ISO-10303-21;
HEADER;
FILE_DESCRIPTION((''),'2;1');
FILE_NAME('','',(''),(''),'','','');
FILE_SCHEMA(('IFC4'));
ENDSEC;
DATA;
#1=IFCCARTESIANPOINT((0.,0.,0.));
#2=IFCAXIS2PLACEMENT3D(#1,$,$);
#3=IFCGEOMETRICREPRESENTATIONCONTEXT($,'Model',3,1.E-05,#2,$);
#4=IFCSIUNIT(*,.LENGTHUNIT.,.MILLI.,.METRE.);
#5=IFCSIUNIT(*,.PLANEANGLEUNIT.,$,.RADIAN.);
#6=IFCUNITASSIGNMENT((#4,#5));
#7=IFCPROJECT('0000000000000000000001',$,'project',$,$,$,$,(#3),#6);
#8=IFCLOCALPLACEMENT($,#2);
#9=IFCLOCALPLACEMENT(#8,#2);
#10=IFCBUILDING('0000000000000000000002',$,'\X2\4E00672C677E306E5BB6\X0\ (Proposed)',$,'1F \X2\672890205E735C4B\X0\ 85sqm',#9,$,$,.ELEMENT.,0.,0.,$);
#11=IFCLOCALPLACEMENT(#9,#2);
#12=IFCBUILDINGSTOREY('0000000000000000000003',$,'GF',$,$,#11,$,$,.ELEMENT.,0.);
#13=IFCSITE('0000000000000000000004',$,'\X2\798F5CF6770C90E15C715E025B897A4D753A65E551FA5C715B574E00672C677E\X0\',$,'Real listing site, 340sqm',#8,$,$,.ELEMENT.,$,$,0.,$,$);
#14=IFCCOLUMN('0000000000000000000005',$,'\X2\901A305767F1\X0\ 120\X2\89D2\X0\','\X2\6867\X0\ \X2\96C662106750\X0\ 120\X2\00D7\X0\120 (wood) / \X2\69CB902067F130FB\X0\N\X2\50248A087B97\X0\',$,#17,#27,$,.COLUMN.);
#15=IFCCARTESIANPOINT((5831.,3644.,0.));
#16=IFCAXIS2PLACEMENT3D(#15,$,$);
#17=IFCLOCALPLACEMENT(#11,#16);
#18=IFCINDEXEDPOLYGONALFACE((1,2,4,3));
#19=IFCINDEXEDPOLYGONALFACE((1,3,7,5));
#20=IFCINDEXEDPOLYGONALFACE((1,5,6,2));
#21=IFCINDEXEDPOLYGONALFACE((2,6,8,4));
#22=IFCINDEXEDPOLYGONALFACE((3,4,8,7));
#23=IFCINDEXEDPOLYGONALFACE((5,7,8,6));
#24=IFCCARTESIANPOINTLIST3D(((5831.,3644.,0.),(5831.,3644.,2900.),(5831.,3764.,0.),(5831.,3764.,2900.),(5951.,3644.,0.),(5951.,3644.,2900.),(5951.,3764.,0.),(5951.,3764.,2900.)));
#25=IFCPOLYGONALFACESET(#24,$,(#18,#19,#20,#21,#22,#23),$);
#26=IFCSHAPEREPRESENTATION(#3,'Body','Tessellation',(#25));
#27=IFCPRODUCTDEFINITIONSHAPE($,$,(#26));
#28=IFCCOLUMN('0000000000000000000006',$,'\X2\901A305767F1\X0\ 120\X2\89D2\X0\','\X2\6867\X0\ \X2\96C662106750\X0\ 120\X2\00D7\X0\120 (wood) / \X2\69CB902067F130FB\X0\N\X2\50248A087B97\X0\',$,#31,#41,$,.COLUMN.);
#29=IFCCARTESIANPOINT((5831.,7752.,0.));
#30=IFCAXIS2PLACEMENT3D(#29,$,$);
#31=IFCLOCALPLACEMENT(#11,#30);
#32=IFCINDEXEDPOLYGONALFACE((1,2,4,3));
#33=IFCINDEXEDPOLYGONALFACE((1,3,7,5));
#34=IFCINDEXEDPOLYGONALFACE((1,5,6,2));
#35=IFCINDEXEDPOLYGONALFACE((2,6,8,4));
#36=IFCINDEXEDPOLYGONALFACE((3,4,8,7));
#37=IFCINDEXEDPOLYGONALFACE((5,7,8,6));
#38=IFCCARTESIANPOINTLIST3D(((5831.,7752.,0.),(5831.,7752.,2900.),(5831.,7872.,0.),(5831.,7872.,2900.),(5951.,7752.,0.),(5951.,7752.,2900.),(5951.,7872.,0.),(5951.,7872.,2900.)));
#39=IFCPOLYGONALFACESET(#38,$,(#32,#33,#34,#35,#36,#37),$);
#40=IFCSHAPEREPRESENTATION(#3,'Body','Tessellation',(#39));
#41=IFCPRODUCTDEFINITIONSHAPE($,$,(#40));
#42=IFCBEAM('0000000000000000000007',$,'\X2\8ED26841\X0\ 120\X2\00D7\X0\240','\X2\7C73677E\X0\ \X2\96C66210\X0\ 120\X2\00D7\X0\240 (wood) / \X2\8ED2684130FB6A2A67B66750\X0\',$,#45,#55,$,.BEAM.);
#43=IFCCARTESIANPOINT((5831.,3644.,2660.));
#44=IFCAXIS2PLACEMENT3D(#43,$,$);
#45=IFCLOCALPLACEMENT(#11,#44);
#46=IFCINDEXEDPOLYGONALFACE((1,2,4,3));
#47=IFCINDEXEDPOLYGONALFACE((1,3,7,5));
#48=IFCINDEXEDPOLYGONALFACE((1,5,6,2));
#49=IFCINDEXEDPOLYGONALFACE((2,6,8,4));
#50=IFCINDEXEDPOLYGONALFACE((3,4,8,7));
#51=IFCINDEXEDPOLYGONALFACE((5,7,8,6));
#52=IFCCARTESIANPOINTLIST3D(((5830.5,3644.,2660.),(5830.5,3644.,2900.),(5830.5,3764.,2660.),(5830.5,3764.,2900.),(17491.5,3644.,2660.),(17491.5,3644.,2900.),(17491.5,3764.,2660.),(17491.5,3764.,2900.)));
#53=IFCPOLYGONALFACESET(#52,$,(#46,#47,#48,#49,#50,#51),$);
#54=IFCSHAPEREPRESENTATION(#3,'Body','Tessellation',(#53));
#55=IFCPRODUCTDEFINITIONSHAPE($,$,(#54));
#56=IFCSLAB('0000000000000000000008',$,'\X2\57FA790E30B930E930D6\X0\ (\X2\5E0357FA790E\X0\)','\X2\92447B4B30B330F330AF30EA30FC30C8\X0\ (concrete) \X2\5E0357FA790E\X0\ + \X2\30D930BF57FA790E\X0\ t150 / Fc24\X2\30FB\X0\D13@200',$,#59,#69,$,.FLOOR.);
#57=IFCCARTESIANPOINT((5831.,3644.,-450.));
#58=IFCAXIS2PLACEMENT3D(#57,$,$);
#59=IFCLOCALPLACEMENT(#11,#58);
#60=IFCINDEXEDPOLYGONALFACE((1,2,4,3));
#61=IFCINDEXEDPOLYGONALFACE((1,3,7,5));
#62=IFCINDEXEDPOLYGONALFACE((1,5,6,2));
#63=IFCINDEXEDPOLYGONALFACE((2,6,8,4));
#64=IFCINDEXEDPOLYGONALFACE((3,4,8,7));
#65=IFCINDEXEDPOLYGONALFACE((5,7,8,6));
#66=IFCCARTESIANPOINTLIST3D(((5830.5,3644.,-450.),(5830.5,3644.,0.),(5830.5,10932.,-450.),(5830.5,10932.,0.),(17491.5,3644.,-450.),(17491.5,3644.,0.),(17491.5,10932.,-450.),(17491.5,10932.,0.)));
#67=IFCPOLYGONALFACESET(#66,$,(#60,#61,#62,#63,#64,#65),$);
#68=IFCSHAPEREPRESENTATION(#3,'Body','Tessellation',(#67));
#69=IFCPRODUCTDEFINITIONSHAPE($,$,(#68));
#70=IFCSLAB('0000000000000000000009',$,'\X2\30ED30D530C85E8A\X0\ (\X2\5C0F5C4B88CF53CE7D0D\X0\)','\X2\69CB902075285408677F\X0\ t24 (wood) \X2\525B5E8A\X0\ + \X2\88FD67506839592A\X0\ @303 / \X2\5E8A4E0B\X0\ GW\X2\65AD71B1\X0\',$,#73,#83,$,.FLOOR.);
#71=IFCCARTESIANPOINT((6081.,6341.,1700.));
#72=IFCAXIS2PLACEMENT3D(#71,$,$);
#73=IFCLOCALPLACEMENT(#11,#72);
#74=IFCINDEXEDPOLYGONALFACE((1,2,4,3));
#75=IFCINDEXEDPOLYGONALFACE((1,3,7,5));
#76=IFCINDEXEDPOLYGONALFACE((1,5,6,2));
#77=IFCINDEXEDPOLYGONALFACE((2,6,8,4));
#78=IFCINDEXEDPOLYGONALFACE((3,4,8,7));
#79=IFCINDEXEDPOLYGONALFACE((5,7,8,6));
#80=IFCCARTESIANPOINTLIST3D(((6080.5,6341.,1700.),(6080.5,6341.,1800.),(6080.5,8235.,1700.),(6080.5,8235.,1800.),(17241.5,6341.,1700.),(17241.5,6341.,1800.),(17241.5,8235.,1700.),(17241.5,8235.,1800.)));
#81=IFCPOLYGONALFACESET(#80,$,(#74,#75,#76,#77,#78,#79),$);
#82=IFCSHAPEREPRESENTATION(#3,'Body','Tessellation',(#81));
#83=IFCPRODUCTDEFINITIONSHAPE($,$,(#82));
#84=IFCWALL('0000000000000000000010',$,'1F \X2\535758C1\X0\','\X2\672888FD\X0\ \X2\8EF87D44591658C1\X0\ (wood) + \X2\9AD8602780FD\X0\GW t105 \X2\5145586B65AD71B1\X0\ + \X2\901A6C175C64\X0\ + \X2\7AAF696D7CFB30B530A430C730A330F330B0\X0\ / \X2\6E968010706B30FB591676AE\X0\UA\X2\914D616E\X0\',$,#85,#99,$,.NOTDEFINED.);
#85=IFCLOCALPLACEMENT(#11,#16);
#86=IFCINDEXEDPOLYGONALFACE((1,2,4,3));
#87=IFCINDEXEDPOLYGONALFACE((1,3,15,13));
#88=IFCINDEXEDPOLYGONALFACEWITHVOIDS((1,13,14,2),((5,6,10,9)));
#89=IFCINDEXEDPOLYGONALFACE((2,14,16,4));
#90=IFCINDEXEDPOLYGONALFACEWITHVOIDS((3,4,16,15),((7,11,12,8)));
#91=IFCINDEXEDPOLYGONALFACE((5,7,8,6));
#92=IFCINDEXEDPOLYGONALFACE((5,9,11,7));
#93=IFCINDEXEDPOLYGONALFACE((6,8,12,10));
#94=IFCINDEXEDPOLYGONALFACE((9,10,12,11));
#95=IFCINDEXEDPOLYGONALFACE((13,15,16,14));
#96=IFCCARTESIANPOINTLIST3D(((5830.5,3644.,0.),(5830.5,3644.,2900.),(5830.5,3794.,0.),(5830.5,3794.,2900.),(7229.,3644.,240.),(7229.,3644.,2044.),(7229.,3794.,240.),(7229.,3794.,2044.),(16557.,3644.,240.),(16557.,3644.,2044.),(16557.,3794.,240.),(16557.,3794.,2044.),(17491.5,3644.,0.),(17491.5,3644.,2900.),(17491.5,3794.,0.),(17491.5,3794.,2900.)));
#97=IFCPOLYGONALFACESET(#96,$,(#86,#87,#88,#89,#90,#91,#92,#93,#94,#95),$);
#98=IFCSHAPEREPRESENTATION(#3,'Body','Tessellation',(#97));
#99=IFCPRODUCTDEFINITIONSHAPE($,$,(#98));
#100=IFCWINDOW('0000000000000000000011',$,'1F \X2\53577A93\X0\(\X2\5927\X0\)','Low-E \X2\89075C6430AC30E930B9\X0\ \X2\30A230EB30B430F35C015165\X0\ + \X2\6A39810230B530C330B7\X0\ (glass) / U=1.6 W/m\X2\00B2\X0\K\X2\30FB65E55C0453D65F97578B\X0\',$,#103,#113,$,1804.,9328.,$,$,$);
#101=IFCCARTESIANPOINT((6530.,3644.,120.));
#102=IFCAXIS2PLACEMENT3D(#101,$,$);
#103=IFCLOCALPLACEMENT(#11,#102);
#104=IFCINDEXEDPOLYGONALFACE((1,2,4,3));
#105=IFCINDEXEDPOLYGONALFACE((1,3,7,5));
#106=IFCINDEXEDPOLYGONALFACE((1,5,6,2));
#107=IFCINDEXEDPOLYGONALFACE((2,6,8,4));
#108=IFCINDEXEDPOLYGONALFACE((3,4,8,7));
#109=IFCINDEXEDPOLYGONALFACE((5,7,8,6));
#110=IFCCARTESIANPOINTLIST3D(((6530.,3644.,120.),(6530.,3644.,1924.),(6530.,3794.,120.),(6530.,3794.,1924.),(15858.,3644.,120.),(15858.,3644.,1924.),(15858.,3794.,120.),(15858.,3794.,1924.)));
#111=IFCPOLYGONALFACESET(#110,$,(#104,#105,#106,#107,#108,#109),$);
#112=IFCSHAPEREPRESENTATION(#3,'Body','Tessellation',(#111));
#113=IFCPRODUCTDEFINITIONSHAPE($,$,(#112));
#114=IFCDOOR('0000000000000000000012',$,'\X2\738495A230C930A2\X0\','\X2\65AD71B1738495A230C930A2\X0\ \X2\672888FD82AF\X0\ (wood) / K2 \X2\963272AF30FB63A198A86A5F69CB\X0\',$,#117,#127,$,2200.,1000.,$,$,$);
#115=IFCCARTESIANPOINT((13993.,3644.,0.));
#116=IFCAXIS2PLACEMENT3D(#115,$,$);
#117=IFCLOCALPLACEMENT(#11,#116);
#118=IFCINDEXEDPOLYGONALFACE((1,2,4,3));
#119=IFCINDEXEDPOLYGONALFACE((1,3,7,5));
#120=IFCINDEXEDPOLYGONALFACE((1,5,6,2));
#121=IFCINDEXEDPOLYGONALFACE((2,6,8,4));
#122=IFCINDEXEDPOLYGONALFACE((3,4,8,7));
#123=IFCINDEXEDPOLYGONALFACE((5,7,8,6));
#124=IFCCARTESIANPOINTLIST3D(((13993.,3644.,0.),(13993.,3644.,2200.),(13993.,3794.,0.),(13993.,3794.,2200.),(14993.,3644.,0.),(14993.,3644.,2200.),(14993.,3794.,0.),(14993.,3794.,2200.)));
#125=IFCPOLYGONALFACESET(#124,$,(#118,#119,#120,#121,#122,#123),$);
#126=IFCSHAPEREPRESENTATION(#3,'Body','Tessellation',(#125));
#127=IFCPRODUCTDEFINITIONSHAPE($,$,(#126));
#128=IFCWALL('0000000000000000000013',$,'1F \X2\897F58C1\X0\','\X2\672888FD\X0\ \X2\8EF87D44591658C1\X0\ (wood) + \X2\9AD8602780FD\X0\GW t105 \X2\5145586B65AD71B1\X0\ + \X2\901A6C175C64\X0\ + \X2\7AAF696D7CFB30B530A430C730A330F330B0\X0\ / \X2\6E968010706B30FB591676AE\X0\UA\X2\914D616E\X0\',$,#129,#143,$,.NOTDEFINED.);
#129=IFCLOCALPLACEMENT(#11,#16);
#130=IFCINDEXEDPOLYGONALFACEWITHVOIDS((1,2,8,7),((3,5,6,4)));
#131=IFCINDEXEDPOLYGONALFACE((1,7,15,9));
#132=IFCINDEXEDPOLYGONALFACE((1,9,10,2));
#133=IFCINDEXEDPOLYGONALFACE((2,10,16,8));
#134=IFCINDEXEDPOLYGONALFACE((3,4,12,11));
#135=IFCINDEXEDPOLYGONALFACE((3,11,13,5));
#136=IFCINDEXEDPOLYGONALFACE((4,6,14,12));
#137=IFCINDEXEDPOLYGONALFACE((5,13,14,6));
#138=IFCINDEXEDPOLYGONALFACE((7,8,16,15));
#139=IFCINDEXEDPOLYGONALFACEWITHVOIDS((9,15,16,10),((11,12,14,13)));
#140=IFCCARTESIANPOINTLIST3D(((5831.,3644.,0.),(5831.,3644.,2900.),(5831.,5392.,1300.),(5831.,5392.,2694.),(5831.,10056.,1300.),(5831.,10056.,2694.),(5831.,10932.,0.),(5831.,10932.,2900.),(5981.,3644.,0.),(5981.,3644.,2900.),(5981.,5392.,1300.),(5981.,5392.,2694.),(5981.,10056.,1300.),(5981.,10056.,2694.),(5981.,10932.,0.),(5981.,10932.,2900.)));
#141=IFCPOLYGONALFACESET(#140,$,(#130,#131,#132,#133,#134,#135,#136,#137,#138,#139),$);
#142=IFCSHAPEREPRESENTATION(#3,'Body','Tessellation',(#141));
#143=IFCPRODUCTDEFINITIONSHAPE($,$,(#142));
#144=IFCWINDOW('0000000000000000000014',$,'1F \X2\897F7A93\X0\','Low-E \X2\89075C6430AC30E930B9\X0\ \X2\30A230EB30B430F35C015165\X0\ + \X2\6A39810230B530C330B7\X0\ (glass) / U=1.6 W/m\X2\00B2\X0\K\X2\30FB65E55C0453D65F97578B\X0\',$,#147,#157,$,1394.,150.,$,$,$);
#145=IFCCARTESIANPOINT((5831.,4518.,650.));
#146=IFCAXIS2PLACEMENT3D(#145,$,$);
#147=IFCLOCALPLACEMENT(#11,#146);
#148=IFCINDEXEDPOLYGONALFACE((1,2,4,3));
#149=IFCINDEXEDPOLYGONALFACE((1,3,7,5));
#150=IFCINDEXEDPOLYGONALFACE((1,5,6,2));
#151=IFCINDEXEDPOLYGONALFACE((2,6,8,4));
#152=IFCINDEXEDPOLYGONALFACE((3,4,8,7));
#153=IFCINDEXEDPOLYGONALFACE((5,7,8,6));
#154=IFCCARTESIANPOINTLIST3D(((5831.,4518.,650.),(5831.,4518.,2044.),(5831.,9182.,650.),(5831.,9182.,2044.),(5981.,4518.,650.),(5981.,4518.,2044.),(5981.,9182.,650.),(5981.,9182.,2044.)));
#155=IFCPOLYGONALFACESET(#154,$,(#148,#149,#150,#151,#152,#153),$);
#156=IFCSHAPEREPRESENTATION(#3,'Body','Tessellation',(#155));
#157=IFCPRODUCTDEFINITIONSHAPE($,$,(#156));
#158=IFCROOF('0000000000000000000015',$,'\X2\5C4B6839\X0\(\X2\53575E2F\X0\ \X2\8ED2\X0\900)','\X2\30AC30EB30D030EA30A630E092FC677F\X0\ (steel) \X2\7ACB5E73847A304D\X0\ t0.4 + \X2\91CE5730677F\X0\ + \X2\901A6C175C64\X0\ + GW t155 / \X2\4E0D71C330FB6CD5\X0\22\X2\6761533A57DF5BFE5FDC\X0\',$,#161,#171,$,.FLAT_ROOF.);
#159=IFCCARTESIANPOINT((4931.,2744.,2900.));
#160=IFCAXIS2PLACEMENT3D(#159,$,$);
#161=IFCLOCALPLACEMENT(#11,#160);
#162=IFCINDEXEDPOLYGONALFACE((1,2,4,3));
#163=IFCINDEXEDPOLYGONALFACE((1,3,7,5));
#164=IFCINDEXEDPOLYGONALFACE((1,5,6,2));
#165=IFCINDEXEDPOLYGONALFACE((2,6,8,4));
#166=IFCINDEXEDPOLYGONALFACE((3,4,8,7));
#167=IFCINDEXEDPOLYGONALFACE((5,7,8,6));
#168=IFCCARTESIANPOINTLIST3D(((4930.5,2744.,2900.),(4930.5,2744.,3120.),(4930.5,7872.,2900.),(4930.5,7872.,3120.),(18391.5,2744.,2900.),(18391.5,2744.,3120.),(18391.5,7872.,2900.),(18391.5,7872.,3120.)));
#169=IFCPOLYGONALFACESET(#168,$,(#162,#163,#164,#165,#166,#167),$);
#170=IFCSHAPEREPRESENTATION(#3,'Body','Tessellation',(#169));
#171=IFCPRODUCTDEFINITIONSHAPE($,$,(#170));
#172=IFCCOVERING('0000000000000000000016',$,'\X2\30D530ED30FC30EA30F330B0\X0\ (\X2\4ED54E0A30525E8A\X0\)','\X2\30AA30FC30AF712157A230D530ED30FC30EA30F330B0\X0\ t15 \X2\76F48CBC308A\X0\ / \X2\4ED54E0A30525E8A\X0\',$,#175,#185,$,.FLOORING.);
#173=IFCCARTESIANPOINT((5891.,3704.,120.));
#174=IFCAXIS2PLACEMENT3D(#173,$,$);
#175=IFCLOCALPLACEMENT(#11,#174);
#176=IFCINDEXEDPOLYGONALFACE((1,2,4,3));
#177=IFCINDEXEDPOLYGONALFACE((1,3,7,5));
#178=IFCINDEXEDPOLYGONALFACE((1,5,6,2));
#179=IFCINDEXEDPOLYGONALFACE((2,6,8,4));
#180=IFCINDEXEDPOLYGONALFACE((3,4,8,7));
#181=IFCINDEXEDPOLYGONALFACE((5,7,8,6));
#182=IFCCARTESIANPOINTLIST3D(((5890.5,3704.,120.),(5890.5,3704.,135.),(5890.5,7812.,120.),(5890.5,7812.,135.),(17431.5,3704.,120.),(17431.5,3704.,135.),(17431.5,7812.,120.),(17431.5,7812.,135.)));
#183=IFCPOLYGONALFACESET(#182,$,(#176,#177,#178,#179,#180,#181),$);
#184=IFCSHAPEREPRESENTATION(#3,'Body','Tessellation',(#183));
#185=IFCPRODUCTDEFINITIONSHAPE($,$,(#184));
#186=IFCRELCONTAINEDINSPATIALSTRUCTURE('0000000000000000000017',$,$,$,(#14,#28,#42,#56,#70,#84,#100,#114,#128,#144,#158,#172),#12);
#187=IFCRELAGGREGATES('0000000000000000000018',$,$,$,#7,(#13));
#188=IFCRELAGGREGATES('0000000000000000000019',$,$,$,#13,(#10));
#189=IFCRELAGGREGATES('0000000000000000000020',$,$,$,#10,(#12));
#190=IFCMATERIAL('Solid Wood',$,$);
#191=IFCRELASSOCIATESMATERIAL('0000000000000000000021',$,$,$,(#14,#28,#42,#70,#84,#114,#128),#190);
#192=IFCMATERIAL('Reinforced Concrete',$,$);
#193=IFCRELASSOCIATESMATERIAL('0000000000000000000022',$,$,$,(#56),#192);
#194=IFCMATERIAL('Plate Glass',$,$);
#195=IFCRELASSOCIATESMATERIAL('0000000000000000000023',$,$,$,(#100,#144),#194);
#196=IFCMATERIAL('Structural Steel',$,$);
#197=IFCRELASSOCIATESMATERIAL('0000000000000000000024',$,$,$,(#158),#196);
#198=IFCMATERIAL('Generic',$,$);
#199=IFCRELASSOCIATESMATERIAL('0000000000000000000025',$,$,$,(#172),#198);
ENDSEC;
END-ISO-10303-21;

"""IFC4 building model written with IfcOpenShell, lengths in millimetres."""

from ifc_helpers import new_model, si_unit, frame, frame_2d, origin, place, context, project, spatial, rectangle, extrude, material, element, fill, save


model = new_model("IFC4")

# Units and contexts
model_context = context("Model", 3, precision=1e-05, world=origin())
ifc_project = project(units=[si_unit("LENGTHUNIT", "METRE", prefix="MILLI"), si_unit("PLANEANGLEUNIT", "RADIAN")], contexts=[model_context])

# Site, building, storey
site_placement = place(None, origin())
site = spatial("IfcSite", under=ifc_project, at=site_placement, Name="福島県郡山市安積町日出山字一本松", ObjectType="Real listing site, 340sqm", CompositionType="ELEMENT", RefElevation=0.0)
building_placement = place(site_placement, origin())
building = spatial("IfcBuilding", under=site, at=building_placement, Name="一本松の家 (Proposed)", ObjectType="1F 木造平屋 85sqm", CompositionType="ELEMENT", ElevationOfRefHeight=0.0, ElevationOfTerrain=0.0)
storey_placement = place(building_placement, origin())
storey = spatial("IfcBuildingStorey", under=building, at=storey_placement, Name="GF", CompositionType="ELEMENT", Elevation=0.0)

# Columns
ifc_material_1 = material(Name="Solid Wood")
column_1_placement = place(storey_placement, frame((5831.0, 3644.0, 0.0)))
element("IfcColumn", 1, at=column_1_placement, inside=storey, material=ifc_material_1, Name="通し柱 120角", Description="桧 集成材 120×120 (wood) / 構造柱・N値計算", PredefinedType="COLUMN", context=model_context, shape_type="SweptSolid", body=[
    extrude(rectangle(XDim=120.0, YDim=120.0, at=frame_2d((60.0, 60.0))), frame((5831.0, 3644.0, 0.0)), (0.0, 0.0, 1.0), 2900.0),
])
column_2_placement = place(storey_placement, frame((5831.0, 7752.0, 0.0)))
element("IfcColumn", 2, at=column_2_placement, inside=storey, material=ifc_material_1, Name="通し柱 120角", Description="桧 集成材 120×120 (wood) / 構造柱・N値計算", PredefinedType="COLUMN", context=model_context, shape_type="SweptSolid", body=[
    extrude(rectangle(XDim=120.0, YDim=120.0, at=frame_2d((60.0, 60.0))), frame((5831.0, 7752.0, 0.0)), (0.0, 0.0, 1.0), 2900.0),
])

# Beam
beam_1_placement = place(storey_placement, frame((5831.0, 3644.0, 2660.0)))
element("IfcBeam", 3, at=beam_1_placement, inside=storey, material=ifc_material_1, Name="軒桁 120×240", Description="米松 集成 120×240 (wood) / 軒桁・横架材", PredefinedType="BEAM", context=model_context, shape_type="SweptSolid", body=[
    extrude(rectangle(XDim=11661.0, YDim=120.0, at=frame_2d((5830.0, 60.0))), frame((5831.0, 3644.0, 2660.0)), (0.0, 0.0, 1.0), 240.0),
])

# Slabs
ifc_material_2 = material(Name="Reinforced Concrete")
slab_1_placement = place(storey_placement, frame((5831.0, 3644.0, -450.0)))
element("IfcSlab", 4, at=slab_1_placement, inside=storey, material=ifc_material_2, Name="基礎スラブ (布基礎)", Description="鉄筋コンクリート (concrete) 布基礎 + ベタ基礎 t150 / Fc24・D13@200", PredefinedType="FLOOR", context=model_context, shape_type="SweptSolid", body=[
    extrude(rectangle(XDim=11661.0, YDim=7288.0, at=frame_2d((5830.0, 3644.0))), frame((5831.0, 3644.0, -450.0)), (0.0, 0.0, 1.0), 450.0),
])
slab_2_placement = place(storey_placement, frame((6081.0, 6341.0, 1700.0)))
element("IfcSlab", 5, at=slab_2_placement, inside=storey, material=ifc_material_1, Name="ロフト床 (小屋裏収納)", Description="構造用合板 t24 (wood) 剛床 + 製材根太 @303 / 床下 GW断熱", PredefinedType="FLOOR", context=model_context, shape_type="SweptSolid", body=[
    extrude(rectangle(XDim=11161.0, YDim=1894.0, at=frame_2d((5580.0, 947.0))), frame((6081.0, 6341.0, 1700.0)), (0.0, 0.0, 1.0), 100.0),
])

# Wall, openings, window, door
wall_1_placement = place(storey_placement, frame((5831.0, 3644.0, 0.0)))
wall_1 = element("IfcWall", 6, at=wall_1_placement, inside=storey, material=ifc_material_1, Name="1F 南壁", Description="木製 軸組外壁 (wood) + 高性能GW t105 充填断熱 + 通気層 + 窯業系サイディング / 準耐火・外皮UA配慮", PredefinedType="NOTDEFINED", context=model_context, shape_type="SweptSolid", body=[
    extrude(rectangle(XDim=11661.0, YDim=150.0, at=frame_2d((5830.0, 75.0))), frame((5831.0, 3644.0, 0.0)), (0.0, 0.0, 1.0), 2900.0),
])
opening_1_placement = place(storey_placement, frame((6530.0, 3644.0, 120.0)))
opening_1 = element("IfcOpeningElement", 7, at=opening_1_placement, cuts=wall_1, PredefinedType="NOTDEFINED", context=model_context, shape_type="SweptSolid", body=[
    extrude(rectangle(XDim=9328.0, YDim=150.0, at=frame_2d((4664.0, 75.0))), frame((6530.0, 3644.0, 120.0)), (0.0, 0.0, 1.0), 1804.0),
])
opening_2_placement = place(storey_placement, frame((13993.0, 3644.0, 0.0)))
opening_2 = element("IfcOpeningElement", 8, at=opening_2_placement, cuts=wall_1, PredefinedType="NOTDEFINED", context=model_context, shape_type="SweptSolid", body=[
    extrude(rectangle(XDim=1000.0, YDim=150.0, at=frame_2d((500.0, 75.0))), frame((13993.0, 3644.0, 0.0)), (0.0, 0.0, 1.0), 2200.0),
])
ifc_material_3 = material(Name="Plate Glass")
window_1_placement = place(storey_placement, frame((6530.0, 3644.0, 120.0)))
window_1 = element("IfcWindow", 9, at=window_1_placement, inside=storey, material=ifc_material_3, Name="1F 南窓(大)", Description="Low-E 複層ガラス アルゴン封入 + 樹脂サッシ (glass) / U=1.6 W/m²K・日射取得型", OverallHeight=1804.0, OverallWidth=9328.0, context=model_context, shape_type="SweptSolid", body=[
    extrude(rectangle(XDim=9328.0, YDim=150.0, at=frame_2d((4664.0, 75.0))), frame((6530.0, 3644.0, 120.0)), (0.0, 0.0, 1.0), 1804.0),
])
fill(opening_1, window_1)
door_placement = place(storey_placement, frame((13993.0, 3644.0, 0.0)))
door = element("IfcDoor", 10, at=door_placement, inside=storey, material=ifc_material_1, Name="玄関ドア", Description="断熱玄関ドア 木製芯 (wood) / K2 防犯・採風機構", OverallHeight=2200.0, OverallWidth=1000.0, context=model_context, shape_type="SweptSolid", body=[
    extrude(rectangle(XDim=1000.0, YDim=150.0, at=frame_2d((500.0, 75.0))), frame((13993.0, 3644.0, 0.0)), (0.0, 0.0, 1.0), 2200.0),
])
fill(opening_2, door)

# Wall, opening, window
wall_2_placement = place(storey_placement, frame((5831.0, 3644.0, 0.0)))
wall_2 = element("IfcWall", 11, at=wall_2_placement, inside=storey, material=ifc_material_1, Name="1F 西壁", Description="木製 軸組外壁 (wood) + 高性能GW t105 充填断熱 + 通気層 + 窯業系サイディング / 準耐火・外皮UA配慮", PredefinedType="NOTDEFINED", context=model_context, shape_type="SweptSolid", body=[
    extrude(rectangle(XDim=150.0, YDim=7288.0, at=frame_2d((75.0, 3644.0))), frame((5831.0, 3644.0, 0.0)), (0.0, 0.0, 1.0), 2900.0),
])
opening_3_placement = place(storey_placement, frame((5831.0, 4518.0, 650.0)))
opening_3 = element("IfcOpeningElement", 12, at=opening_3_placement, cuts=wall_2, PredefinedType="NOTDEFINED", context=model_context, shape_type="SweptSolid", body=[
    extrude(rectangle(XDim=150.0, YDim=4664.0, at=frame_2d((75.0, 2332.0))), frame((5831.0, 4518.0, 650.0)), (0.0, 0.0, 1.0), 1394.0),
])
window_2_placement = place(storey_placement, frame((5831.0, 4518.0, 650.0)))
window_2 = element("IfcWindow", 13, at=window_2_placement, inside=storey, material=ifc_material_3, Name="1F 西窓", Description="Low-E 複層ガラス アルゴン封入 + 樹脂サッシ (glass) / U=1.6 W/m²K・日射取得型", OverallHeight=1394.0, OverallWidth=150.0, context=model_context, shape_type="SweptSolid", body=[
    extrude(rectangle(XDim=150.0, YDim=4664.0, at=frame_2d((75.0, 2332.0))), frame((5831.0, 4518.0, 650.0)), (0.0, 0.0, 1.0), 1394.0),
])
fill(opening_3, window_2)

# Roof
ifc_material_4 = material(Name="Structural Steel")
roof_placement = place(storey_placement, frame((4931.0, 2744.0, 2900.0)))
element("IfcRoof", 14, at=roof_placement, inside=storey, material=ifc_material_4, Name="屋根(南帯 軒900)", Description="ガルバリウム鋼板 (steel) 立平葺き t0.4 + 野地板 + 通気層 + GW t155 / 不燃・法22条区域対応", PredefinedType="FLAT_ROOF", context=model_context, shape_type="SweptSolid", body=[
    extrude(rectangle(XDim=13461.0, YDim=5128.0, at=frame_2d((6730.0, 2564.0))), frame((4931.0, 2744.0, 2900.0)), (0.0, 0.0, 1.0), 220.0),
])

# Covering
ifc_material_5 = material(Name="Generic")
covering_1_placement = place(storey_placement, frame((5891.0, 3704.0, 120.0)))
element("IfcCovering", 15, at=covering_1_placement, inside=storey, material=ifc_material_5, Name="フローリング (仕上げ床)", Description="オーク無垢フローリング t15 直貼り / 仕上げ床", PredefinedType="FLOORING", context=model_context, shape_type="SweptSolid", body=[
    extrude(rectangle(XDim=11541.0, YDim=4108.0, at=frame_2d((5770.0, 2054.0))), frame((5891.0, 3704.0, 120.0)), (0.0, 0.0, 1.0), 15.0),
])

save(model, "model.ifc")
